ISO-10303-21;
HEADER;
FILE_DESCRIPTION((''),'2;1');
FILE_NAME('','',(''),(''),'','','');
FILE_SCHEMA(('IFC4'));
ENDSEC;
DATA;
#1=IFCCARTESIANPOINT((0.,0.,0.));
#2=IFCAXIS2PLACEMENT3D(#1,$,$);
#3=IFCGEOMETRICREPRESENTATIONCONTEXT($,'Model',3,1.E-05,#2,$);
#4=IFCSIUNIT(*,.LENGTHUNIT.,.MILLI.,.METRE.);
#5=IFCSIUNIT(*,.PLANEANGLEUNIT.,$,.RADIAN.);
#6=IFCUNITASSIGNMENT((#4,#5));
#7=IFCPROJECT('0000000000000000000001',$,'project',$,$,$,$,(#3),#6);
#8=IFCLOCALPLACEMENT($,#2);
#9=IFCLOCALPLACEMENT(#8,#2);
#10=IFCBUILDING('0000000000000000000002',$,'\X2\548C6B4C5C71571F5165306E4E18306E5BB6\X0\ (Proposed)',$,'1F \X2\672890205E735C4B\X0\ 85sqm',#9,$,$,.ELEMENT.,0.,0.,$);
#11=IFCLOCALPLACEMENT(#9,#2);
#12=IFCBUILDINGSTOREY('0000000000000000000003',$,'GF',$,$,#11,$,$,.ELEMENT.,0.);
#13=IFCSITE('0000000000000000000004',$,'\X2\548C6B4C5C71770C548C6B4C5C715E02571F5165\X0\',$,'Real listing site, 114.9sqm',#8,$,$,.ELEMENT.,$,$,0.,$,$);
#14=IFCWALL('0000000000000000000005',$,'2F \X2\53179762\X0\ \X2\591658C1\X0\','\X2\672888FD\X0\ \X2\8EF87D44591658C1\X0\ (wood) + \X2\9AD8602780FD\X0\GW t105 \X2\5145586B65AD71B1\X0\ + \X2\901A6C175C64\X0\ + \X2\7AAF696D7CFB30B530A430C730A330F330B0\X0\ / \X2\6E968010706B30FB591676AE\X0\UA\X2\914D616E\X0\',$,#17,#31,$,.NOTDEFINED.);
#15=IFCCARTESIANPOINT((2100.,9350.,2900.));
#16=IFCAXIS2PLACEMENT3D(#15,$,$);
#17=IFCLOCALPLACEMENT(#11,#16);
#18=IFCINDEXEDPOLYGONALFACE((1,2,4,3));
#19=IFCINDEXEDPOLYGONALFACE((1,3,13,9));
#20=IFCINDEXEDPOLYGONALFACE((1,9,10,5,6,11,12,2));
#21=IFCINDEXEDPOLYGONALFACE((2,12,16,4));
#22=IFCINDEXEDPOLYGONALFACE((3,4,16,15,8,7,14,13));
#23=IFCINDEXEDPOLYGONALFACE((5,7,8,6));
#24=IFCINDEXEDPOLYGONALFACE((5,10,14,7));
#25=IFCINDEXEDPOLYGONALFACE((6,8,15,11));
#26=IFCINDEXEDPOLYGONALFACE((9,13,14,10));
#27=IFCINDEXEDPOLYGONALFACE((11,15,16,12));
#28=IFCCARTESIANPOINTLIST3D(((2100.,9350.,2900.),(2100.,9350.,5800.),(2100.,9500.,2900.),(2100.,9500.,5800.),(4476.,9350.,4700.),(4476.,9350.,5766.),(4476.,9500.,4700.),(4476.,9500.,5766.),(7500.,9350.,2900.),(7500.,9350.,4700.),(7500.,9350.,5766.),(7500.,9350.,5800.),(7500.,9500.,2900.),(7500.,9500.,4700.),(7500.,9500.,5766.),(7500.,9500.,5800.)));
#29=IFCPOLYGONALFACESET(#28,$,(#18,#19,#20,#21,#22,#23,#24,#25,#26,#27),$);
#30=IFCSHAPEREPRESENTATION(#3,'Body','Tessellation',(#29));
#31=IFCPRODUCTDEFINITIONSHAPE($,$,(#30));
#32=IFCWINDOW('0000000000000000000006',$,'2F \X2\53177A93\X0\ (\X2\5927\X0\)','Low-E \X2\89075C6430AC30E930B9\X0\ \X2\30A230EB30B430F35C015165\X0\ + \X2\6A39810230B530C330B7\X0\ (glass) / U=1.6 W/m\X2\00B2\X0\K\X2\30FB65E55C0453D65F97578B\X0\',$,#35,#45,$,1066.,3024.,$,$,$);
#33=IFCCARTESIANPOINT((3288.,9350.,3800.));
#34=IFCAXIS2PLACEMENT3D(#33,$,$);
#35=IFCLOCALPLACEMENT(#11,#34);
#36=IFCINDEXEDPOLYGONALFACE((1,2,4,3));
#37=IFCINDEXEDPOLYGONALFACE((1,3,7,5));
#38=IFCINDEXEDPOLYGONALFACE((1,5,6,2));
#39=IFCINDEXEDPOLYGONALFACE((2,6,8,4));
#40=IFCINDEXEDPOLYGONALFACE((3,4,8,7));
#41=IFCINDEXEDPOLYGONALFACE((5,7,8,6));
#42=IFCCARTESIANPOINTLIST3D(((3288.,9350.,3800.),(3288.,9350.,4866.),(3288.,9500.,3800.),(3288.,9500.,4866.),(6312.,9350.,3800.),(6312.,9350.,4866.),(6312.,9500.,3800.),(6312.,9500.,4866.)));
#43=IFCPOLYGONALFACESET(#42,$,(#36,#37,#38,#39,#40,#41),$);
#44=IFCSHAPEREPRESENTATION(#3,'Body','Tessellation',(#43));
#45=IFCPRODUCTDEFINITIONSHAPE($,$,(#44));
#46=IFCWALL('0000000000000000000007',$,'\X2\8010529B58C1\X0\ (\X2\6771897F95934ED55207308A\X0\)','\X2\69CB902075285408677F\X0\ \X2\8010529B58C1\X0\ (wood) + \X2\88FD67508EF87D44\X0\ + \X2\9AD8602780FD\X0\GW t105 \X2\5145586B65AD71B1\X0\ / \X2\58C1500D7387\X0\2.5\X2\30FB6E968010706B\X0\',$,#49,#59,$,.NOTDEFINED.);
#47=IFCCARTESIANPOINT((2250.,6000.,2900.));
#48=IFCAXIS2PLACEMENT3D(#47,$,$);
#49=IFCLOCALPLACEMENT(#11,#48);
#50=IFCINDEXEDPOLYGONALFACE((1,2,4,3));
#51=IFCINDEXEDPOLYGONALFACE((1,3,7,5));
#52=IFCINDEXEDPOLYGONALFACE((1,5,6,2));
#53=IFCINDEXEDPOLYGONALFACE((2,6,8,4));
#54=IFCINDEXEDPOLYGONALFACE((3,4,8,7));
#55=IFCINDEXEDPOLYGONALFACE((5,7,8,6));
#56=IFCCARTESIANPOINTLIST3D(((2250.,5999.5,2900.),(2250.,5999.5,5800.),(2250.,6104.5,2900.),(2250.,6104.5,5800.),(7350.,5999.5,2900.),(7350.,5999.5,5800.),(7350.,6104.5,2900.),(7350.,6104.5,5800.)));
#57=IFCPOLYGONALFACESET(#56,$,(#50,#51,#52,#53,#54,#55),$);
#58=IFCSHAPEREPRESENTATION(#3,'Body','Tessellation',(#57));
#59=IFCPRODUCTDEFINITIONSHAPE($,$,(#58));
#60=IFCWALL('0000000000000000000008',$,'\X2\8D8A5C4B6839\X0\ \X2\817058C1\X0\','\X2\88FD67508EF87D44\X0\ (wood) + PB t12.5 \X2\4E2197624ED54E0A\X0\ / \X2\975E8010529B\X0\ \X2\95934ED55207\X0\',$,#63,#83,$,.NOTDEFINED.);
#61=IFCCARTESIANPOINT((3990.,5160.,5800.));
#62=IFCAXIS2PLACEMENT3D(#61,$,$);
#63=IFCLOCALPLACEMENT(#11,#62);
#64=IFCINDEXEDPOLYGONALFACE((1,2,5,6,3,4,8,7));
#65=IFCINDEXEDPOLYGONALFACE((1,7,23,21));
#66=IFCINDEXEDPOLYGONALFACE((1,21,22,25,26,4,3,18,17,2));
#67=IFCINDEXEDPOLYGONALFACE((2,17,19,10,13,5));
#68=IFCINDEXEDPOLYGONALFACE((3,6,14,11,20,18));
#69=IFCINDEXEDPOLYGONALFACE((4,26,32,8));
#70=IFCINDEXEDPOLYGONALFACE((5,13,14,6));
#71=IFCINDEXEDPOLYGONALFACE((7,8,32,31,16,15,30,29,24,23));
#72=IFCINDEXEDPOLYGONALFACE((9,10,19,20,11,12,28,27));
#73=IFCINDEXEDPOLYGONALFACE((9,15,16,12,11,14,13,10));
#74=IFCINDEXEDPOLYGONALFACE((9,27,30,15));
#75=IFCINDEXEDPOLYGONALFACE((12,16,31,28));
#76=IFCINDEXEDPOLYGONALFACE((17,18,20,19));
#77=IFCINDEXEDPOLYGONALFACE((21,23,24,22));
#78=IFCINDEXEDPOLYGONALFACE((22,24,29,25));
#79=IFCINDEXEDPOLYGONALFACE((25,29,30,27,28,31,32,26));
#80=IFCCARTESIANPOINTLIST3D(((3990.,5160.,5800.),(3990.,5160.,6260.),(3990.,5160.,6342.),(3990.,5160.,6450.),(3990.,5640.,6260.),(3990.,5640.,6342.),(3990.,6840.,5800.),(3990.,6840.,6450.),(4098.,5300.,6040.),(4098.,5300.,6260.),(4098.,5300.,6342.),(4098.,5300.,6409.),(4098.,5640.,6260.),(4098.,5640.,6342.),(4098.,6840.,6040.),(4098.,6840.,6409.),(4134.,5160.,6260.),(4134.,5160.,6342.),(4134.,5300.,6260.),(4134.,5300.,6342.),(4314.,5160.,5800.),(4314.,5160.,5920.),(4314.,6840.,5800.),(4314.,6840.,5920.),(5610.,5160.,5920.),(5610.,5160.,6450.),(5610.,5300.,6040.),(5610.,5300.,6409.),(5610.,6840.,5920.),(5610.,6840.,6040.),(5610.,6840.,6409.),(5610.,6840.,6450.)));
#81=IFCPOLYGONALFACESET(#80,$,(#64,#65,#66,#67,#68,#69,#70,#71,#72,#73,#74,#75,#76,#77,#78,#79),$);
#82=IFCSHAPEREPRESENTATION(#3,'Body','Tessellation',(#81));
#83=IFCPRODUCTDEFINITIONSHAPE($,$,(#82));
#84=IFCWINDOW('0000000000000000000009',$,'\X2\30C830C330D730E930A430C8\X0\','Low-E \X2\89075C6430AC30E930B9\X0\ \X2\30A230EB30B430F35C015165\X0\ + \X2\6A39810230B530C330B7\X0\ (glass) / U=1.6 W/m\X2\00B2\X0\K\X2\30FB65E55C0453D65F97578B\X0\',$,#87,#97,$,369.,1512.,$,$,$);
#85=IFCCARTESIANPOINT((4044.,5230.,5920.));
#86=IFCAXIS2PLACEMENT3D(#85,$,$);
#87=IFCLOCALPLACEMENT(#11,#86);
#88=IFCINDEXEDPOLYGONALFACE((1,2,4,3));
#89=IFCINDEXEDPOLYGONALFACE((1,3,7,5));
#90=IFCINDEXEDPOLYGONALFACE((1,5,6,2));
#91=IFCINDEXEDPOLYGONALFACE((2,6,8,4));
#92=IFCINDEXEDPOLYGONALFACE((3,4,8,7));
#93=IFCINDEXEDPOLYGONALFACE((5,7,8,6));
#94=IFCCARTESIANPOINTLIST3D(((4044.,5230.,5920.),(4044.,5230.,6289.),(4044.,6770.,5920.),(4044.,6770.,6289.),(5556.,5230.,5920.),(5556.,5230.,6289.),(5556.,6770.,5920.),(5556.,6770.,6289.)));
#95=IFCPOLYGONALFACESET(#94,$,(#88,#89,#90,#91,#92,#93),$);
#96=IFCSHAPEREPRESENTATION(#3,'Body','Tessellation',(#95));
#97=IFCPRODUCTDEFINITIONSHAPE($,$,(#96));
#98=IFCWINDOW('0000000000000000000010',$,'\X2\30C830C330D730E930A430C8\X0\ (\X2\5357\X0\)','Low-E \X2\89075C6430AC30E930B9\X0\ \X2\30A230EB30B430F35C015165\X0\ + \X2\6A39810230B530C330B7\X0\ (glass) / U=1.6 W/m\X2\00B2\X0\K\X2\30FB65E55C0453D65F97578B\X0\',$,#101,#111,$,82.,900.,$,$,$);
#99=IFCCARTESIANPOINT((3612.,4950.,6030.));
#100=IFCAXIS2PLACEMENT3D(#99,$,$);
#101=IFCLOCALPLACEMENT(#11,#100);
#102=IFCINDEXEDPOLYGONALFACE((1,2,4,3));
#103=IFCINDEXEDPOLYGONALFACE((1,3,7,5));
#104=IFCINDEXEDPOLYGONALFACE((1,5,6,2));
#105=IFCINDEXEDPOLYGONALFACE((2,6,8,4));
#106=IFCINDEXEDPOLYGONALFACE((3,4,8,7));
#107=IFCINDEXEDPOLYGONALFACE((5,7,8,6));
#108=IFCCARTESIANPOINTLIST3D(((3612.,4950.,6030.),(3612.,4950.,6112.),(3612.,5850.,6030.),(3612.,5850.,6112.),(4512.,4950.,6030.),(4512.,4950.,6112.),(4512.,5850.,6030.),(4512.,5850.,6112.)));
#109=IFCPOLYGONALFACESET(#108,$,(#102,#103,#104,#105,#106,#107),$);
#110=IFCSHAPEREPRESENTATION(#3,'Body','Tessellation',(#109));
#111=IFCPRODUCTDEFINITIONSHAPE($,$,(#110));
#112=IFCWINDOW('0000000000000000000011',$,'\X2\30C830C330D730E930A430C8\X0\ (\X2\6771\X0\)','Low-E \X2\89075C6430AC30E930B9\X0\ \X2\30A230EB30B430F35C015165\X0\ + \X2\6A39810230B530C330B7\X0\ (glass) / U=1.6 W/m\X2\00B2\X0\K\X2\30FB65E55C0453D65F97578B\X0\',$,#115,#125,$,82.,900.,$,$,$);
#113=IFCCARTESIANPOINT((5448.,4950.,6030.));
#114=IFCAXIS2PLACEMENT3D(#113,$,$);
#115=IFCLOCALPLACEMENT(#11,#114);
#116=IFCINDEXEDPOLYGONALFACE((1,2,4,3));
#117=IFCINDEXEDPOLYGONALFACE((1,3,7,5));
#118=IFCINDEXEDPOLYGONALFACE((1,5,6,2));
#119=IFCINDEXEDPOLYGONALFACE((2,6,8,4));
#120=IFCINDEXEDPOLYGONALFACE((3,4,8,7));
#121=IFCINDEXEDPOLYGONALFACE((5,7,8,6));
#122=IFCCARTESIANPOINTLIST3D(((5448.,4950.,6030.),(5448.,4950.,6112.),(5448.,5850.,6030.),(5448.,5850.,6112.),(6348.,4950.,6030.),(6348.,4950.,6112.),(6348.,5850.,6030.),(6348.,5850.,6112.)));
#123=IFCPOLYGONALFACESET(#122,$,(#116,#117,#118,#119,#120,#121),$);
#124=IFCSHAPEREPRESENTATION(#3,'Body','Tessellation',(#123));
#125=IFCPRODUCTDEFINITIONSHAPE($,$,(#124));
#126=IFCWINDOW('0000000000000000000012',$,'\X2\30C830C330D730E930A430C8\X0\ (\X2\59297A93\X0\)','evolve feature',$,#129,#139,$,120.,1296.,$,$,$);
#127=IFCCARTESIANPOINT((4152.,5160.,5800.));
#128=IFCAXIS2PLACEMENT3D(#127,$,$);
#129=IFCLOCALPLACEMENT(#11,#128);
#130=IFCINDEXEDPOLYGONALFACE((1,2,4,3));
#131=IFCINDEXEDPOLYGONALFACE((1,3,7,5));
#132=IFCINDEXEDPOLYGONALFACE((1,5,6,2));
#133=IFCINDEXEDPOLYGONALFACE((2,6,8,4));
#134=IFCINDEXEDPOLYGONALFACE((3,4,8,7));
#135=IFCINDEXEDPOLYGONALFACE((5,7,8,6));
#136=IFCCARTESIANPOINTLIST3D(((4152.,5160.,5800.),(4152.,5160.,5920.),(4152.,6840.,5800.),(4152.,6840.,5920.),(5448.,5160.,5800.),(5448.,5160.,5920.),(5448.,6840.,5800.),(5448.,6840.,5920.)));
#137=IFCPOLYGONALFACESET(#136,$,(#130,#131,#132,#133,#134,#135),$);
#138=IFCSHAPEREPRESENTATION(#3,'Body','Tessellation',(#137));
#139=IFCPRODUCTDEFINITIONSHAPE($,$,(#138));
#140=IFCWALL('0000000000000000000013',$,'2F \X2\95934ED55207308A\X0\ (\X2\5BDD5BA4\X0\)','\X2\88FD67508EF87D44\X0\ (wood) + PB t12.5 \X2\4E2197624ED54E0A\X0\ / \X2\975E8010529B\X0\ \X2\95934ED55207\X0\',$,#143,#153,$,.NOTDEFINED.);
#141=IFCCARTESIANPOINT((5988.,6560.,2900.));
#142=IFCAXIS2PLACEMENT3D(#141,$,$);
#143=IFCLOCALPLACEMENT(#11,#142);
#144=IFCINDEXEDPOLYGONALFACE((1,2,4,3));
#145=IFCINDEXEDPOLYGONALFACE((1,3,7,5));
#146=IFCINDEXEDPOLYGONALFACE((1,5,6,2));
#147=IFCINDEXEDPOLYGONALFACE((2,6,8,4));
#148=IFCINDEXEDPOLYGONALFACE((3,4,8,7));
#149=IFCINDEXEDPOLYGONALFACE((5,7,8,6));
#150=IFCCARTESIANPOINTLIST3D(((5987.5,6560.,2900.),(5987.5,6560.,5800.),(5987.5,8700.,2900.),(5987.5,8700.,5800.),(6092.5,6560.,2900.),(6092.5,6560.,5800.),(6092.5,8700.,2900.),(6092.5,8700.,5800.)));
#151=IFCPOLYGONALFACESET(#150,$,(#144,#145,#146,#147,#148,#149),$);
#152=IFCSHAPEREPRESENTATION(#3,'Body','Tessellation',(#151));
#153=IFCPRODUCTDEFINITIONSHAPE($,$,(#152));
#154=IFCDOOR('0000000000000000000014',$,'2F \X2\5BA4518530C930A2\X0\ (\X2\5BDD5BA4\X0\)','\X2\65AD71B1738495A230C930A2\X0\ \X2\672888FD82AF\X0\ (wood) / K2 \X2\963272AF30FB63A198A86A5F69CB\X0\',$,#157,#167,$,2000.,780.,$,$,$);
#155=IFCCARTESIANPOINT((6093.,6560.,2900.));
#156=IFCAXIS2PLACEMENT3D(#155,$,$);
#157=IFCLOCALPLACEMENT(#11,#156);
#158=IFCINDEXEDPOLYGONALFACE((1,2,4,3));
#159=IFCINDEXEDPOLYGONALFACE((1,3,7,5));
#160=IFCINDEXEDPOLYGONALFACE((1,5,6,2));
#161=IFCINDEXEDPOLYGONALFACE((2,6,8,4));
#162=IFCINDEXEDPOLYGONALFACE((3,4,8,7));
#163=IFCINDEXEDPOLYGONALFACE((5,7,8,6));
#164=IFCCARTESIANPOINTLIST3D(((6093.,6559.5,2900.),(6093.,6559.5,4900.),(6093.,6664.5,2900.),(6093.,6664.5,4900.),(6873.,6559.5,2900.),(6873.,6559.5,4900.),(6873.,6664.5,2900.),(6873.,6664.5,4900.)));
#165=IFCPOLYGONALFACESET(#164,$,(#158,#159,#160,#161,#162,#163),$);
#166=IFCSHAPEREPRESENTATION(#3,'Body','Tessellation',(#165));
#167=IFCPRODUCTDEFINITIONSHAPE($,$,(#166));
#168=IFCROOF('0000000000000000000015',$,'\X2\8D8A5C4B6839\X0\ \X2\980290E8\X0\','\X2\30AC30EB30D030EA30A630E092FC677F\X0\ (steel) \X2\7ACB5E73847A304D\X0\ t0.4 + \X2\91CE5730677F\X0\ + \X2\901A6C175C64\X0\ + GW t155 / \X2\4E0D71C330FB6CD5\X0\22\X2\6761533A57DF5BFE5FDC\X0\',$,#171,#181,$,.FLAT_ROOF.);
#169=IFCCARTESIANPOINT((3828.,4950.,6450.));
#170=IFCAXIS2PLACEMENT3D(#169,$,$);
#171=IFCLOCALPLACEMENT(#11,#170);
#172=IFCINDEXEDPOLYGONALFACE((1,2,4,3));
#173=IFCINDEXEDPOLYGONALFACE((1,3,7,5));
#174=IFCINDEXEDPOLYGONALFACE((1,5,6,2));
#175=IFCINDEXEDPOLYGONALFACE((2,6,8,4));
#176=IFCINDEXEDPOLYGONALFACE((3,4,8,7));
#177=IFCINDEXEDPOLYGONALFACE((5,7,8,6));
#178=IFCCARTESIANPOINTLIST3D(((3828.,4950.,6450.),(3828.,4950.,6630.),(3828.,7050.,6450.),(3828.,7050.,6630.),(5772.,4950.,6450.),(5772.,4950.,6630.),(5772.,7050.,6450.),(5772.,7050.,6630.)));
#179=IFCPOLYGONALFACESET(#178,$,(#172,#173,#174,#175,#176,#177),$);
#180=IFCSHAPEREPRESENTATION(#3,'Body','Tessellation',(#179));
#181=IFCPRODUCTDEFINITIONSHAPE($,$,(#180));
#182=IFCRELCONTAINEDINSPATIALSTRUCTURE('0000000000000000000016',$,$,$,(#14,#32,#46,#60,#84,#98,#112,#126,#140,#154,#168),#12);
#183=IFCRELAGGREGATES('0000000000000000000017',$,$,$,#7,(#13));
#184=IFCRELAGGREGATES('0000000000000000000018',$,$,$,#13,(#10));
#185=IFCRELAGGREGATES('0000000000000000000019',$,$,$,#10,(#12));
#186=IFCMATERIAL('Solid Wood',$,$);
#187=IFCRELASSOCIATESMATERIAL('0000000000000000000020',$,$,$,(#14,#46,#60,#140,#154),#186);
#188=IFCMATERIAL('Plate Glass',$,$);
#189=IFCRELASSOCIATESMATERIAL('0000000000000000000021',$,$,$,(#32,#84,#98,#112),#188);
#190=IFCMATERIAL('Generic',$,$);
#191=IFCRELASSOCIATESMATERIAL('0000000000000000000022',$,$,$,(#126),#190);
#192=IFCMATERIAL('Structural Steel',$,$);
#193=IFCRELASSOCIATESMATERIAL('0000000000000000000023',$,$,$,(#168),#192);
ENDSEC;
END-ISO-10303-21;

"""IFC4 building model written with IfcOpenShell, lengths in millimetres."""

from ifc_helpers import new_model, si_unit, frame, frame_2d, origin, place, context, project, spatial, rectangle, extrude, material, element, fill, save


model = new_model("IFC4")

# Units and contexts
model_context = context("Model", 3, precision=1e-05, world=origin())
ifc_project = project(units=[si_unit("LENGTHUNIT", "METRE", prefix="MILLI"), si_unit("PLANEANGLEUNIT", "RADIAN")], contexts=[model_context])

# Site, building, storey
site_placement = place(None, origin())
site = spatial("IfcSite", under=ifc_project, at=site_placement, Name="和歌山県和歌山市土入", ObjectType="Real listing site, 114.9sqm", CompositionType="ELEMENT", RefElevation=0.0)
building_placement = place(site_placement, origin())
building = spatial("IfcBuilding", under=site, at=building_placement, Name="和歌山土入の丘の家 (Proposed)", ObjectType="1F 木造平屋 85sqm", CompositionType="ELEMENT", ElevationOfRefHeight=0.0, ElevationOfTerrain=0.0)
storey_placement = place(building_placement, origin())
storey = spatial("IfcBuildingStorey", under=building, at=storey_placement, Name="GF", CompositionType="ELEMENT", Elevation=0.0)

# Wall, opening, window
ifc_material_1 = material(Name="Solid Wood")
wall_1_placement = place(storey_placement, frame((2100.0, 9350.0, 2900.0)))
wall_1 = element("IfcWall", 1, at=wall_1_placement, inside=storey, material=ifc_material_1, Name="2F 北面 外壁", Description="木製 軸組外壁 (wood) + 高性能GW t105 充填断熱 + 通気層 + 窯業系サイディング / 準耐火・外皮UA配慮", PredefinedType="NOTDEFINED", context=model_context, shape_type="SweptSolid", body=[
    extrude(rectangle(XDim=5400.0, YDim=150.0, at=frame_2d((2700.0, 75.0))), frame((2100.0, 9350.0, 2900.0)), (0.0, 0.0, 1.0), 2900.0),
])
opening_1_placement = place(storey_placement, frame((3288.0, 9350.0, 3800.0)))
opening_1 = element("IfcOpeningElement", 2, at=opening_1_placement, cuts=wall_1, PredefinedType="NOTDEFINED", context=model_context, shape_type="SweptSolid", body=[
    extrude(rectangle(XDim=3024.0, YDim=150.0, at=frame_2d((1512.0, 75.0))), frame((3288.0, 9350.0, 3800.0)), (0.0, 0.0, 1.0), 1066.0),
])
ifc_material_2 = material(Name="Plate Glass")
window_1_placement = place(storey_placement, frame((3288.0, 9350.0, 3800.0)))
window_1 = element("IfcWindow", 3, at=window_1_placement, inside=storey, material=ifc_material_2, Name="2F 北窓 (大)", Description="Low-E 複層ガラス アルゴン封入 + 樹脂サッシ (glass) / U=1.6 W/m²K・日射取得型", OverallHeight=1066.0, OverallWidth=3024.0, context=model_context, shape_type="SweptSolid", body=[
    extrude(rectangle(XDim=3024.0, YDim=150.0, at=frame_2d((1512.0, 75.0))), frame((3288.0, 9350.0, 3800.0)), (0.0, 0.0, 1.0), 1066.0),
])
fill(opening_1, window_1)

# Wall
wall_2_placement = place(storey_placement, frame((2250.0, 6000.0, 2900.0)))
element("IfcWall", 4, at=wall_2_placement, inside=storey, material=ifc_material_1, Name="耐力壁 (東西間仕切り)", Description="構造用合板 耐力壁 (wood) + 製材軸組 + 高性能GW t105 充填断熱 / 壁倍率2.5・準耐火", PredefinedType="NOTDEFINED", context=model_context, shape_type="SweptSolid", body=[
    extrude(rectangle(XDim=5100.0, YDim=105.0, at=frame_2d((2550.0, 52.0))), frame((2250.0, 6000.0, 2900.0)), (0.0, 0.0, 1.0), 2900.0),
])

# Wall, openings, windows
wall_3_placement = place(storey_placement, frame((3990.0, 5160.0, 5800.0)))
wall_3 = element("IfcWall", 5, at=wall_3_placement, inside=storey, material=ifc_material_1, Name="越屋根 腰壁", Description="製材軸組 (wood) + PB t12.5 両面仕上 / 非耐力 間仕切", PredefinedType="NOTDEFINED", context=model_context, shape_type="SweptSolid", body=[
    extrude(rectangle(XDim=1620.0, YDim=1680.0, at=frame_2d((810.0, 840.0))), frame((3990.0, 5160.0, 5800.0)), (0.0, 0.0, 1.0), 650.0),
])
opening_2_placement = place(storey_placement, frame((4044.0, 5230.0, 5920.0)))
opening_2 = element("IfcOpeningElement", 6, at=opening_2_placement, cuts=wall_3, PredefinedType="NOTDEFINED", context=model_context, shape_type="SweptSolid", body=[
    extrude(rectangle(XDim=1512.0, YDim=1540.0, at=frame_2d((756.0, 770.0))), frame((4044.0, 5230.0, 5920.0)), (0.0, 0.0, 1.0), 369.0),
])
opening_3_placement = place(storey_placement, frame((3612.0, 4950.0, 6030.0)))
opening_3 = element("IfcOpeningElement", 7, at=opening_3_placement, cuts=wall_3, PredefinedType="NOTDEFINED", context=model_context, shape_type="SweptSolid", body=[
    extrude(rectangle(XDim=900.0, YDim=900.0, at=frame_2d((450.0, 450.0))), frame((3612.0, 4950.0, 6030.0)), (0.0, 0.0, 1.0), 82.0),
])
opening_4_placement = place(storey_placement, frame((5448.0, 4950.0, 6030.0)))
opening_4 = element("IfcOpeningElement", 8, at=opening_4_placement, cuts=wall_3, PredefinedType="NOTDEFINED", context=model_context, shape_type="SweptSolid", body=[
    extrude(rectangle(XDim=900.0, YDim=900.0, at=frame_2d((450.0, 450.0))), frame((5448.0, 4950.0, 6030.0)), (0.0, 0.0, 1.0), 82.0),
])
opening_5_placement = place(storey_placement, frame((4152.0, 5160.0, 5800.0)))
opening_5 = element("IfcOpeningElement", 9, at=opening_5_placement, cuts=wall_3, PredefinedType="NOTDEFINED", context=model_context, shape_type="SweptSolid", body=[
    extrude(rectangle(XDim=1296.0, YDim=1680.0, at=frame_2d((648.0, 840.0))), frame((4152.0, 5160.0, 5800.0)), (0.0, 0.0, 1.0), 120.0),
])
window_2_placement = place(storey_placement, frame((4044.0, 5230.0, 5920.0)))
window_2 = element("IfcWindow", 10, at=window_2_placement, inside=storey, material=ifc_material_2, Name="トップライト", Description="Low-E 複層ガラス アルゴン封入 + 樹脂サッシ (glass) / U=1.6 W/m²K・日射取得型", OverallHeight=369.0, OverallWidth=1512.0, context=model_context, shape_type="SweptSolid", body=[
    extrude(rectangle(XDim=1512.0, YDim=1540.0, at=frame_2d((756.0, 770.0))), frame((4044.0, 5230.0, 5920.0)), (0.0, 0.0, 1.0), 369.0),
])
fill(opening_2, window_2)
window_3_placement = place(storey_placement, frame((3612.0, 4950.0, 6030.0)))
window_3 = element("IfcWindow", 11, at=window_3_placement, inside=storey, material=ifc_material_2, Name="トップライト (南)", Description="Low-E 複層ガラス アルゴン封入 + 樹脂サッシ (glass) / U=1.6 W/m²K・日射取得型", OverallHeight=82.0, OverallWidth=900.0, context=model_context, shape_type="SweptSolid", body=[
    extrude(rectangle(XDim=900.0, YDim=900.0, at=frame_2d((450.0, 450.0))), frame((3612.0, 4950.0, 6030.0)), (0.0, 0.0, 1.0), 82.0),
])
fill(opening_3, window_3)
window_4_placement = place(storey_placement, frame((5448.0, 4950.0, 6030.0)))
window_4 = element("IfcWindow", 12, at=window_4_placement, inside=storey, material=ifc_material_2, Name="トップライト (東)", Description="Low-E 複層ガラス アルゴン封入 + 樹脂サッシ (glass) / U=1.6 W/m²K・日射取得型", OverallHeight=82.0, OverallWidth=900.0, context=model_context, shape_type="SweptSolid", body=[
    extrude(rectangle(XDim=900.0, YDim=900.0, at=frame_2d((450.0, 450.0))), frame((5448.0, 4950.0, 6030.0)), (0.0, 0.0, 1.0), 82.0),
])
fill(opening_4, window_4)
ifc_material_3 = material(Name="Generic")
window_5_placement = place(storey_placement, frame((4152.0, 5160.0, 5800.0)))
window_5 = element("IfcWindow", 13, at=window_5_placement, inside=storey, material=ifc_material_3, Name="トップライト (天窓)", Description="evolve feature", OverallHeight=120.0, OverallWidth=1296.0, context=model_context, shape_type="SweptSolid", body=[
    extrude(rectangle(XDim=1296.0, YDim=1680.0, at=frame_2d((648.0, 840.0))), frame((4152.0, 5160.0, 5800.0)), (0.0, 0.0, 1.0), 120.0),
])
fill(opening_5, window_5)

# Wall
wall_4_placement = place(storey_placement, frame((5988.0, 6560.0, 2900.0)))
element("IfcWall", 14, at=wall_4_placement, inside=storey, material=ifc_material_1, Name="2F 間仕切り (寝室)", Description="製材軸組 (wood) + PB t12.5 両面仕上 / 非耐力 間仕切", PredefinedType="NOTDEFINED", context=model_context, shape_type="SweptSolid", body=[
    extrude(rectangle(XDim=105.0, YDim=2140.0, at=frame_2d((52.0, 1070.0))), frame((5988.0, 6560.0, 2900.0)), (0.0, 0.0, 1.0), 2900.0),
])

# Door
door_placement = place(storey_placement, frame((6093.0, 6560.0, 2900.0)))
element("IfcDoor", 15, at=door_placement, inside=storey, material=ifc_material_1, Name="2F 室内ドア (寝室)", Description="断熱玄関ドア 木製芯 (wood) / K2 防犯・採風機構", OverallHeight=2000.0, OverallWidth=780.0, context=model_context, shape_type="SweptSolid", body=[
    extrude(rectangle(XDim=780.0, YDim=105.0, at=frame_2d((390.0, 52.0))), frame((6093.0, 6560.0, 2900.0)), (0.0, 0.0, 1.0), 2000.0),
])

# Roof
ifc_material_4 = material(Name="Structural Steel")
roof_placement = place(storey_placement, frame((3828.0, 4950.0, 6450.0)))
element("IfcRoof", 16, at=roof_placement, inside=storey, material=ifc_material_4, Name="越屋根 頂部", Description="ガルバリウム鋼板 (steel) 立平葺き t0.4 + 野地板 + 通気層 + GW t155 / 不燃・法22条区域対応", PredefinedType="FLAT_ROOF", context=model_context, shape_type="SweptSolid", body=[
    extrude(rectangle(XDim=1944.0, YDim=2100.0, at=frame_2d((972.0, 1050.0))), frame((3828.0, 4950.0, 6450.0)), (0.0, 0.0, 1.0), 180.0),
])

save(model, "model.ifc")
